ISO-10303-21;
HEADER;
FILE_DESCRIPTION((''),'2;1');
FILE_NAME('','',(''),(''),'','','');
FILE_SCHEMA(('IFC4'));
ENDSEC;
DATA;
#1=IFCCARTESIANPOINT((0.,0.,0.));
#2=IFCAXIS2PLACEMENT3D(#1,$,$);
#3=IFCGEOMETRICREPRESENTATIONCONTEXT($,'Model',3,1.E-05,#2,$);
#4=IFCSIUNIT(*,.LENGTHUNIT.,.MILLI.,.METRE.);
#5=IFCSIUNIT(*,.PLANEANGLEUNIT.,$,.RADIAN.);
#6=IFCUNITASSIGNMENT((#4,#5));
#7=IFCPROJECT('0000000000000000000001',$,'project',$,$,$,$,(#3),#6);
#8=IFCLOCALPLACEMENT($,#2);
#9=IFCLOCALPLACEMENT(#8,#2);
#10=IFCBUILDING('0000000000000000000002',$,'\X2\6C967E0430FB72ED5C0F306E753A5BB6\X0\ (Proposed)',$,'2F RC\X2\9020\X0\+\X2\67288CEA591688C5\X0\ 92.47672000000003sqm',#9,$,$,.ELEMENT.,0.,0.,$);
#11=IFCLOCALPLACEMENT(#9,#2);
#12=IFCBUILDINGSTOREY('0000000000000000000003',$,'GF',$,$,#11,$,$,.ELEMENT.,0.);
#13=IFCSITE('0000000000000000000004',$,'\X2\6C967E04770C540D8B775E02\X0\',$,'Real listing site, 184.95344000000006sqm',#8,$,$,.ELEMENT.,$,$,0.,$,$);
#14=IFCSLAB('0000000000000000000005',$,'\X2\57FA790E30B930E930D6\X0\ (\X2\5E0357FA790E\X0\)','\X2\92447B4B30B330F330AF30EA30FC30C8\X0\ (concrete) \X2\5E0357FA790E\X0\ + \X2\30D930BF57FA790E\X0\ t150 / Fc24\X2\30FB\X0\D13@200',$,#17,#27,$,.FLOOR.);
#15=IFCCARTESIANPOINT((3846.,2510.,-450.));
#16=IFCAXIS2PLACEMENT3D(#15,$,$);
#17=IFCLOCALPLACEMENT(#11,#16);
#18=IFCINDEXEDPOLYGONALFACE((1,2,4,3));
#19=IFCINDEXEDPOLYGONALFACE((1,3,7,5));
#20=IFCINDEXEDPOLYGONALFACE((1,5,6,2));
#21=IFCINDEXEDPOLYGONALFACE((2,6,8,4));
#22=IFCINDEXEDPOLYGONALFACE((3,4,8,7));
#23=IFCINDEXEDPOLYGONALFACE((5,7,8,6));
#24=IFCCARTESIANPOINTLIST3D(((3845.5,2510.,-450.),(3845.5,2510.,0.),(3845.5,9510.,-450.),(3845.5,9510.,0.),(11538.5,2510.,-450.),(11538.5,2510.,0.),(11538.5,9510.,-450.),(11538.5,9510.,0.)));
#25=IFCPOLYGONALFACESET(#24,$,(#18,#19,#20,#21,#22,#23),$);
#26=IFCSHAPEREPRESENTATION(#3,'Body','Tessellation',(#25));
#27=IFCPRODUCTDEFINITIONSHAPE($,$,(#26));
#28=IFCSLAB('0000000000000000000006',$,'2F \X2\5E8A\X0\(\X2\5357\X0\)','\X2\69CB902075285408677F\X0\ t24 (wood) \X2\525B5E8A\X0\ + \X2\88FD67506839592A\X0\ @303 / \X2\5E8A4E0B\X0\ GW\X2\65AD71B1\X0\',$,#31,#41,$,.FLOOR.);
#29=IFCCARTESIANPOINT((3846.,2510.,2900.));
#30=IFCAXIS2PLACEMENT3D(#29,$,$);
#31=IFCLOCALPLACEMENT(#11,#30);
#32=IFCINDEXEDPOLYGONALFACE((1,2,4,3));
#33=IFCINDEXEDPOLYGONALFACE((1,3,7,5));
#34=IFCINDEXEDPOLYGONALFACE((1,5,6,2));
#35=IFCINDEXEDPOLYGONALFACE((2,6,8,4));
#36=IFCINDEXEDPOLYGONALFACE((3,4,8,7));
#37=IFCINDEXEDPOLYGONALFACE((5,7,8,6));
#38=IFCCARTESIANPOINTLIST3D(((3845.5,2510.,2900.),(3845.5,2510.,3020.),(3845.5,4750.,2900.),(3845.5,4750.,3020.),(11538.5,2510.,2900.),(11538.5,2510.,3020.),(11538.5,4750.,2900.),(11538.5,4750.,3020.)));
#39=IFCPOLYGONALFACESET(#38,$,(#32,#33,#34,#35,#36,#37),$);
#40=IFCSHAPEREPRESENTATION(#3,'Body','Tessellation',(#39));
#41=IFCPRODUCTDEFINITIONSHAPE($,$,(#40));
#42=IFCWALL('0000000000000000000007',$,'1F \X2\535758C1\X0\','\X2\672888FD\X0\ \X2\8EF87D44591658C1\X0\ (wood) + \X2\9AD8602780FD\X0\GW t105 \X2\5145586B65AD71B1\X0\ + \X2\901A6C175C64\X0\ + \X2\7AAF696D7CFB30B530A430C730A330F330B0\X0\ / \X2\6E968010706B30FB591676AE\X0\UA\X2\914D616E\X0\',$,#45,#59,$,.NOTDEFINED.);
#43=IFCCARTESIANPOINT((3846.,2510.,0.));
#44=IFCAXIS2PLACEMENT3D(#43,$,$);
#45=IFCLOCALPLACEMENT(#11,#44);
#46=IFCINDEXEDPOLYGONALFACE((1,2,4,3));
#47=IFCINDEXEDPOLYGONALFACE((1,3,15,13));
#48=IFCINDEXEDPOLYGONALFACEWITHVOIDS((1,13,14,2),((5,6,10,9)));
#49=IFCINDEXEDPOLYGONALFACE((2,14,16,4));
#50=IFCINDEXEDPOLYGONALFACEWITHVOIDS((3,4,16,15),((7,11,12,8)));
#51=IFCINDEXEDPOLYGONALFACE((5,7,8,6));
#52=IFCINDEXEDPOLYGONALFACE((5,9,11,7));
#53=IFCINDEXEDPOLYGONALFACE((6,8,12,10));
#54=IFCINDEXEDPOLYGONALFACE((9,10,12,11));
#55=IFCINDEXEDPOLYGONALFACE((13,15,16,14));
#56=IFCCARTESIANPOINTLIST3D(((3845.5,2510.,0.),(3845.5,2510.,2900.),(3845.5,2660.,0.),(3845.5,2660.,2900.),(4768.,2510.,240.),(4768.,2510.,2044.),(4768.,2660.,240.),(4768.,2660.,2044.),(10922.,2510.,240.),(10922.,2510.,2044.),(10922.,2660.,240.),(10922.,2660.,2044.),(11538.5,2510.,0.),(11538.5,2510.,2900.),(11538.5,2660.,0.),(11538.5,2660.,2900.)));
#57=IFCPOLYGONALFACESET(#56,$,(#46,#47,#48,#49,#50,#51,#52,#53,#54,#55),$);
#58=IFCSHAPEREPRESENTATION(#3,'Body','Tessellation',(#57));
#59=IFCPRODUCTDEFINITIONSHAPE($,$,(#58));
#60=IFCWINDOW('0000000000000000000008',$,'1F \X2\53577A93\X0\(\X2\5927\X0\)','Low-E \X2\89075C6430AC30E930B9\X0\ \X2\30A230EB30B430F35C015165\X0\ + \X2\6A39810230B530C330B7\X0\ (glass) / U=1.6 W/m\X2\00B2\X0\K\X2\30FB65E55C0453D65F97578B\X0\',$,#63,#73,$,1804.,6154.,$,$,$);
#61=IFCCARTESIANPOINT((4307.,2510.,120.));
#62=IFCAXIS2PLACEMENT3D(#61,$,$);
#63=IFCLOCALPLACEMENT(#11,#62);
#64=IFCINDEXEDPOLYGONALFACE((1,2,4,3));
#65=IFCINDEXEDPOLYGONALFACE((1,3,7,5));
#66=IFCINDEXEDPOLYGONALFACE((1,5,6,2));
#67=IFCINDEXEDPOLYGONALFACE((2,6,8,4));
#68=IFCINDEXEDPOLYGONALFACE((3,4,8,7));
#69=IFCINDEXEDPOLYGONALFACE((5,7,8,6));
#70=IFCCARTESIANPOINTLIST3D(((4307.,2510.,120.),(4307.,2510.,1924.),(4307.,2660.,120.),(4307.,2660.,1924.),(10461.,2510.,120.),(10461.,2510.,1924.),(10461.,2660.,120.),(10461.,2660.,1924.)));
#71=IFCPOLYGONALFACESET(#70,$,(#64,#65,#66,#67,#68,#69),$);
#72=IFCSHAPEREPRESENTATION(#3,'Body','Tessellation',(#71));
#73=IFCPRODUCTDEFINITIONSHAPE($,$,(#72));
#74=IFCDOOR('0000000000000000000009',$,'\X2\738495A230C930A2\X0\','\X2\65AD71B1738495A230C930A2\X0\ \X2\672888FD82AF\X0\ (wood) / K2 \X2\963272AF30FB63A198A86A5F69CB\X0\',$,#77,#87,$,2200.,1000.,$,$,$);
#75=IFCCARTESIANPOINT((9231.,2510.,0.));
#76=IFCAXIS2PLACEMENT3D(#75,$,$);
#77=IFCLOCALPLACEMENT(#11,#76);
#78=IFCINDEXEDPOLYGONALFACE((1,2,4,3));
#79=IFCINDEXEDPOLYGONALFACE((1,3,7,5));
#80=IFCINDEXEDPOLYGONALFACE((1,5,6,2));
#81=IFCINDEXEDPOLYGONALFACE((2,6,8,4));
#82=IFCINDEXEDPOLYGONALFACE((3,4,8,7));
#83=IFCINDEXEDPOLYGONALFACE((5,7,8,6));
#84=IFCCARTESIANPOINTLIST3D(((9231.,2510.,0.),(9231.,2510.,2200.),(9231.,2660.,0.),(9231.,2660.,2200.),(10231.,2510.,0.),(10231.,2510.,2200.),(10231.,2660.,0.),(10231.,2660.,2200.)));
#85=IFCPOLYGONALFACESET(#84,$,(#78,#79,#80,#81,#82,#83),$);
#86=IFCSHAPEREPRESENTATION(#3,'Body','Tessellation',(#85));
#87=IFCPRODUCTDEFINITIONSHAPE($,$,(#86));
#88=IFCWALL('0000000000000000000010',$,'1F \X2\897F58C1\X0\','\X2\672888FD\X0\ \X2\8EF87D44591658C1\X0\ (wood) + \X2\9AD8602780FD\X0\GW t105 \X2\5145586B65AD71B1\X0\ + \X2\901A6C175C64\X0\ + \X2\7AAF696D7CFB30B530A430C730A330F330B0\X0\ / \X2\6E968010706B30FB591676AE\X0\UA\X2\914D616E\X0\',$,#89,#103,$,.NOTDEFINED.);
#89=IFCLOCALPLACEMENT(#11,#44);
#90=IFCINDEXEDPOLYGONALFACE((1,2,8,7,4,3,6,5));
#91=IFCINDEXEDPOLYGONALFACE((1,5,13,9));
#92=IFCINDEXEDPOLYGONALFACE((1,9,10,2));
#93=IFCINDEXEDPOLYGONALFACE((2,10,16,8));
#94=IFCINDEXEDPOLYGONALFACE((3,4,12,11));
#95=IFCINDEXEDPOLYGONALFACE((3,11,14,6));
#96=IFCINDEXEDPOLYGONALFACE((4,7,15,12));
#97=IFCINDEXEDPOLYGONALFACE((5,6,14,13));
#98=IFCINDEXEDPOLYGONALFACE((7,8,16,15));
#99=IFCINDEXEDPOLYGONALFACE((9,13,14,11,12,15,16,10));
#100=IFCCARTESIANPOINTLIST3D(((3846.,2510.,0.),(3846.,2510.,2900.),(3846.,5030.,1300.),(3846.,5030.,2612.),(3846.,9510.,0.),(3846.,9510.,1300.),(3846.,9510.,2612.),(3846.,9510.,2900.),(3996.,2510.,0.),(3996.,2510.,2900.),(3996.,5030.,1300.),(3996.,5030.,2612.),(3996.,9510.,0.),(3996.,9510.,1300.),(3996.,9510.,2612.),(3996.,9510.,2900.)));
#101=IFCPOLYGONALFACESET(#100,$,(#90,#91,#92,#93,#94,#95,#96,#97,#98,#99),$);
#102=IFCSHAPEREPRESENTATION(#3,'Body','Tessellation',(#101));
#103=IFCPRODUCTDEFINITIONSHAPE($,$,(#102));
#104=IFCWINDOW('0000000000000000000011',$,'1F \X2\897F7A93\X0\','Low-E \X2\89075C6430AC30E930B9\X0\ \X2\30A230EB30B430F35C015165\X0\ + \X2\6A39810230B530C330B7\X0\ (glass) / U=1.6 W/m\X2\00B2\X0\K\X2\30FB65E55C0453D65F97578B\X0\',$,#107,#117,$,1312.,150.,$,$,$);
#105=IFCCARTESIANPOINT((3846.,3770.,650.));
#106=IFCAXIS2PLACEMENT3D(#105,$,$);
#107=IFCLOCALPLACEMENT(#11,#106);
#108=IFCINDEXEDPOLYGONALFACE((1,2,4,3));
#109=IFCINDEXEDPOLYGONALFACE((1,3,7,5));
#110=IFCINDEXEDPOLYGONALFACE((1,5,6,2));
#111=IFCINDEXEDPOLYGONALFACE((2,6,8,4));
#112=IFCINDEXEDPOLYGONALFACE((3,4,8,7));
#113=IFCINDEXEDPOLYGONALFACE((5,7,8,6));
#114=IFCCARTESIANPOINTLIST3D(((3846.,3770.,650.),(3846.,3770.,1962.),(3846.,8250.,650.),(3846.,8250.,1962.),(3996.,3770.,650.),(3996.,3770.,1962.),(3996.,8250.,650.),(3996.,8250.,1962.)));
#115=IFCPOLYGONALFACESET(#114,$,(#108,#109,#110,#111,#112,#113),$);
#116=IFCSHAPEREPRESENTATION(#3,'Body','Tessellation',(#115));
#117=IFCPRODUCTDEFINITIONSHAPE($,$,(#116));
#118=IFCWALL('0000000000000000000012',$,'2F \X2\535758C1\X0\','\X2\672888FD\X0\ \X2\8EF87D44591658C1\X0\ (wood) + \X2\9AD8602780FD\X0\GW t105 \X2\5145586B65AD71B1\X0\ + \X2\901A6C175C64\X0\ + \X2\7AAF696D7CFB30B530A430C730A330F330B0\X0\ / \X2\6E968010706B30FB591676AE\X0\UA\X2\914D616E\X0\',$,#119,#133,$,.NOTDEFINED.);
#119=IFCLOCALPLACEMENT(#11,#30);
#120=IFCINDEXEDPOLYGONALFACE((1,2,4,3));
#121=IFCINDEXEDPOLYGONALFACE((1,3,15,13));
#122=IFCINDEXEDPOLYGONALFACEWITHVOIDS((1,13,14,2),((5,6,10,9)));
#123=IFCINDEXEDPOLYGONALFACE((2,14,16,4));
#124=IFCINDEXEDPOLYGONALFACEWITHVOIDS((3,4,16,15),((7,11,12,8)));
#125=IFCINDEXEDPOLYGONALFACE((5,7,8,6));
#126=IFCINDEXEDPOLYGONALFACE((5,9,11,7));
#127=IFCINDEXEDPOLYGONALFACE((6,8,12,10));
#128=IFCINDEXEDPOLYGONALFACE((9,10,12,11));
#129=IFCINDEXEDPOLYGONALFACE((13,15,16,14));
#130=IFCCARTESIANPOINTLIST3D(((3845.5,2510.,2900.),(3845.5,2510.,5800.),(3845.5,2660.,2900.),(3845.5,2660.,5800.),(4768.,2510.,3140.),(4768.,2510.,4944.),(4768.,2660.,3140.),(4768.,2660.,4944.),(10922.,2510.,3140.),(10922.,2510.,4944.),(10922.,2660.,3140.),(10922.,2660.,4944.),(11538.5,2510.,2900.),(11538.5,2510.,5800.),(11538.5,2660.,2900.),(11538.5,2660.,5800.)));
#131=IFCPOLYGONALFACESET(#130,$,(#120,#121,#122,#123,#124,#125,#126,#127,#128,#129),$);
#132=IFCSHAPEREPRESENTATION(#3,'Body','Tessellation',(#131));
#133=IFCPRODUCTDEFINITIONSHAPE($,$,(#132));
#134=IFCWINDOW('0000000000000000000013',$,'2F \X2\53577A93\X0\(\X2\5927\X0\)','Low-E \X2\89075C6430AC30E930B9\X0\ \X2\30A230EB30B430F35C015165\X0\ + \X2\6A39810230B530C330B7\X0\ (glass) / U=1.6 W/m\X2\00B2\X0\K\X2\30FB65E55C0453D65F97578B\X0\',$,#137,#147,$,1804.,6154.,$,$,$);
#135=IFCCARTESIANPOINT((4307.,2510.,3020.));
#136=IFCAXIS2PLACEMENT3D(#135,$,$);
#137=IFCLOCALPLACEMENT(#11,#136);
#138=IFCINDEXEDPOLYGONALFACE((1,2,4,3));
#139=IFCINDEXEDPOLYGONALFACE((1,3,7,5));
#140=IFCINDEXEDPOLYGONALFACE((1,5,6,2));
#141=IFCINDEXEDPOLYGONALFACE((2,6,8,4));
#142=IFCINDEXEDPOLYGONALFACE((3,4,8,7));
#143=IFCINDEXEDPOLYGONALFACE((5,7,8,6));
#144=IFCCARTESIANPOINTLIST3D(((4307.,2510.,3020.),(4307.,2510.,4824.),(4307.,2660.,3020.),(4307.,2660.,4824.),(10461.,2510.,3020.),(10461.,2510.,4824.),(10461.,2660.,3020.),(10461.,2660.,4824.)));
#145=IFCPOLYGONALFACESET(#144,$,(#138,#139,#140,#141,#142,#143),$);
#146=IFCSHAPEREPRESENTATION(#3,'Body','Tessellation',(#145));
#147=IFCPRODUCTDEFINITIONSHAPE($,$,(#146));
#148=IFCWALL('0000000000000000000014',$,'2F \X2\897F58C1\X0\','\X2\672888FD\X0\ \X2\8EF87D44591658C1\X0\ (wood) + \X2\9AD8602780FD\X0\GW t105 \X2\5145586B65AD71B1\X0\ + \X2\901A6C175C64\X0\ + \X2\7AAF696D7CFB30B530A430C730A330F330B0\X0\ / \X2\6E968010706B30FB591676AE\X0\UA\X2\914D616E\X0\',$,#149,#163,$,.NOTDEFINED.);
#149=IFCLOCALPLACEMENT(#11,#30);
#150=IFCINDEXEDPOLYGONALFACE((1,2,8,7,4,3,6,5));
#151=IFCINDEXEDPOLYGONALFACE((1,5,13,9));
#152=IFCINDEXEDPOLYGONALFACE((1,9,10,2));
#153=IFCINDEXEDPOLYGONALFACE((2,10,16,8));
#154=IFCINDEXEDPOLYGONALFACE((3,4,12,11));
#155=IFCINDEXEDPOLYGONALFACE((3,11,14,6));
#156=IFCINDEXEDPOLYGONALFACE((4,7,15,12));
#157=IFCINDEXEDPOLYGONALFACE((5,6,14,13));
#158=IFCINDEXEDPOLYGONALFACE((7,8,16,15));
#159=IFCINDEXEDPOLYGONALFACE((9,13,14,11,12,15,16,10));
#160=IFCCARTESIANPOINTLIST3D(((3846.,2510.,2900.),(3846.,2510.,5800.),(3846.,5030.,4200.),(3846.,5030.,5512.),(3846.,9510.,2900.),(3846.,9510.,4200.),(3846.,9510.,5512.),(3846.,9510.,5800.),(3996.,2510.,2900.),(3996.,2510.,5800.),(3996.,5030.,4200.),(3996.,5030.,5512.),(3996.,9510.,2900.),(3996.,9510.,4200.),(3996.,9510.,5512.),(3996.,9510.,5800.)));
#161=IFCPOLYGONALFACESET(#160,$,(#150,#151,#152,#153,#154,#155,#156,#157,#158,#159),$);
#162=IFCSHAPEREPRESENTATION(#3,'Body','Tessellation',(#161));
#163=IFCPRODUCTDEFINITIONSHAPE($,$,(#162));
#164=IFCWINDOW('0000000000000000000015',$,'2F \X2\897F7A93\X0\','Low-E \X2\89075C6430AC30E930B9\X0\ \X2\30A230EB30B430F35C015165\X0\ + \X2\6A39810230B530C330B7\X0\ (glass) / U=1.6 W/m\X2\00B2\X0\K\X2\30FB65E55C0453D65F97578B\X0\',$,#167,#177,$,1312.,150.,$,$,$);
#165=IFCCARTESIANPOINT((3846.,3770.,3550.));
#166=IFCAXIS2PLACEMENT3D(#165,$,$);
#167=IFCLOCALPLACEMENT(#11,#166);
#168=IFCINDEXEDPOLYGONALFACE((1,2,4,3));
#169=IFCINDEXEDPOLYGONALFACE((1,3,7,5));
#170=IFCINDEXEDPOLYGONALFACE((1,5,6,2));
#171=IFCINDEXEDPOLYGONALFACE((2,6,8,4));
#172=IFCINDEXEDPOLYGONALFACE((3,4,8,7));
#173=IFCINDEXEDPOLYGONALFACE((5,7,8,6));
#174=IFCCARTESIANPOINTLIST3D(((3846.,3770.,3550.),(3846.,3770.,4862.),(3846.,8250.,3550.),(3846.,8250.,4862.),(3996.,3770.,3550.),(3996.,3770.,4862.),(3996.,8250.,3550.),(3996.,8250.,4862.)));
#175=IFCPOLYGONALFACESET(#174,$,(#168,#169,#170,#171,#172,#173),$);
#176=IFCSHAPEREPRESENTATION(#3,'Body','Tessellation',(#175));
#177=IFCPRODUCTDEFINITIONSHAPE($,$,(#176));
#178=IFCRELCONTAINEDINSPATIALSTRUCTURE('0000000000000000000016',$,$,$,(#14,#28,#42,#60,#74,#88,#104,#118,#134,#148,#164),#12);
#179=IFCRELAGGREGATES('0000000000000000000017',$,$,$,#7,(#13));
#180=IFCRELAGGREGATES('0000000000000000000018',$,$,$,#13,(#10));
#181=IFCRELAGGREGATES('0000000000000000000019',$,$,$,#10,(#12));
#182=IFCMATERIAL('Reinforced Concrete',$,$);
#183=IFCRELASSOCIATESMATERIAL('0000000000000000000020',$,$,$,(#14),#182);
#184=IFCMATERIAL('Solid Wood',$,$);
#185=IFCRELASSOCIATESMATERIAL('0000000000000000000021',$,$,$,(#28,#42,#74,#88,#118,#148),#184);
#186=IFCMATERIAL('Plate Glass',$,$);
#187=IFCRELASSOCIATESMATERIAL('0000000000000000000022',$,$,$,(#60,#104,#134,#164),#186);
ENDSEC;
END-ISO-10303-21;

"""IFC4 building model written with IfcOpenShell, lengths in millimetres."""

from ifc_helpers import new_model, si_unit, frame, frame_2d, origin, place, context, project, spatial, rectangle, extrude, material, element, fill, save


model = new_model("IFC4")

# Units and contexts
model_context = context("Model", 3, precision=1e-05, world=origin())
ifc_project = project(units=[si_unit("LENGTHUNIT", "METRE", prefix="MILLI"), si_unit("PLANEANGLEUNIT", "RADIAN")], contexts=[model_context])

# Site, building, storey
site_placement = place(None, origin())
site = spatial("IfcSite", under=ifc_project, at=site_placement, Name="沖縄県名護市", ObjectType="Real listing site, 184.95344000000006sqm", CompositionType="ELEMENT", RefElevation=0.0)
building_placement = place(site_placement, origin())
building = spatial("IfcBuilding", under=site, at=building_placement, Name="沖縄・狭小の町家 (Proposed)", ObjectType="2F RC造+木質外装 92.47672000000003sqm", CompositionType="ELEMENT", ElevationOfRefHeight=0.0, ElevationOfTerrain=0.0)
storey_placement = place(building_placement, origin())
storey = spatial("IfcBuildingStorey", under=building, at=storey_placement, Name="GF", CompositionType="ELEMENT", Elevation=0.0)

# Slabs
ifc_material_1 = material(Name="Reinforced Concrete")
slab_1_placement = place(storey_placement, frame((3846.0, 2510.0, -450.0)))
element("IfcSlab", 1, at=slab_1_placement, inside=storey, material=ifc_material_1, Name="基礎スラブ (布基礎)", Description="鉄筋コンクリート (concrete) 布基礎 + ベタ基礎 t150 / Fc24・D13@200", PredefinedType="FLOOR", context=model_context, shape_type="SweptSolid", body=[
    extrude(rectangle(XDim=7693.0, YDim=7000.0, at=frame_2d((3846.0, 3500.0))), frame((3846.0, 2510.0, -450.0)), (0.0, 0.0, 1.0), 450.0),
])
ifc_material_2 = material(Name="Solid Wood")
slab_2_placement = place(storey_placement, frame((3846.0, 2510.0, 2900.0)))
element("IfcSlab", 2, at=slab_2_placement, inside=storey, material=ifc_material_2, Name="2F 床(南)", Description="構造用合板 t24 (wood) 剛床 + 製材根太 @303 / 床下 GW断熱", PredefinedType="FLOOR", context=model_context, shape_type="SweptSolid", body=[
    extrude(rectangle(XDim=7693.0, YDim=2240.0, at=frame_2d((3846.0, 1120.0))), frame((3846.0, 2510.0, 2900.0)), (0.0, 0.0, 1.0), 120.0),
])

# Wall, openings, window, door
wall_1_placement = place(storey_placement, frame((3846.0, 2510.0, 0.0)))
wall_1 = element("IfcWall", 3, at=wall_1_placement, inside=storey, material=ifc_material_2, Name="1F 南壁", Description="木製 軸組外壁 (wood) + 高性能GW t105 充填断熱 + 通気層 + 窯業系サイディング / 準耐火・外皮UA配慮", PredefinedType="NOTDEFINED", context=model_context, shape_type="SweptSolid", body=[
    extrude(rectangle(XDim=7693.0, YDim=150.0, at=frame_2d((3846.0, 75.0))), frame((3846.0, 2510.0, 0.0)), (0.0, 0.0, 1.0), 2900.0),
])
opening_1_placement = place(storey_placement, frame((4307.0, 2510.0, 120.0)))
opening_1 = element("IfcOpeningElement", 4, at=opening_1_placement, cuts=wall_1, PredefinedType="NOTDEFINED", context=model_context, shape_type="SweptSolid", body=[
    extrude(rectangle(XDim=6154.0, YDim=150.0, at=frame_2d((3077.0, 75.0))), frame((4307.0, 2510.0, 120.0)), (0.0, 0.0, 1.0), 1804.0),
])
opening_2_placement = place(storey_placement, frame((9231.0, 2510.0, 0.0)))
opening_2 = element("IfcOpeningElement", 5, at=opening_2_placement, cuts=wall_1, PredefinedType="NOTDEFINED", context=model_context, shape_type="SweptSolid", body=[
    extrude(rectangle(XDim=1000.0, YDim=150.0, at=frame_2d((500.0, 75.0))), frame((9231.0, 2510.0, 0.0)), (0.0, 0.0, 1.0), 2200.0),
])
ifc_material_3 = material(Name="Plate Glass")
window_1_placement = place(storey_placement, frame((4307.0, 2510.0, 120.0)))
window_1 = element("IfcWindow", 6, at=window_1_placement, inside=storey, material=ifc_material_3, Name="1F 南窓(大)", Description="Low-E 複層ガラス アルゴン封入 + 樹脂サッシ (glass) / U=1.6 W/m²K・日射取得型", OverallHeight=1804.0, OverallWidth=6154.0, context=model_context, shape_type="SweptSolid", body=[
    extrude(rectangle(XDim=6154.0, YDim=150.0, at=frame_2d((3077.0, 75.0))), frame((4307.0, 2510.0, 120.0)), (0.0, 0.0, 1.0), 1804.0),
])
fill(opening_1, window_1)
door_placement = place(storey_placement, frame((9231.0, 2510.0, 0.0)))
door = element("IfcDoor", 7, at=door_placement, inside=storey, material=ifc_material_2, Name="玄関ドア", Description="断熱玄関ドア 木製芯 (wood) / K2 防犯・採風機構", OverallHeight=2200.0, OverallWidth=1000.0, context=model_context, shape_type="SweptSolid", body=[
    extrude(rectangle(XDim=1000.0, YDim=150.0, at=frame_2d((500.0, 75.0))), frame((9231.0, 2510.0, 0.0)), (0.0, 0.0, 1.0), 2200.0),
])
fill(opening_2, door)

# Walls, openings, windows
wall_2_placement = place(storey_placement, frame((3846.0, 2510.0, 0.0)))
wall_2 = element("IfcWall", 8, at=wall_2_placement, inside=storey, material=ifc_material_2, Name="1F 西壁", Description="木製 軸組外壁 (wood) + 高性能GW t105 充填断熱 + 通気層 + 窯業系サイディング / 準耐火・外皮UA配慮", PredefinedType="NOTDEFINED", context=model_context, shape_type="SweptSolid", body=[
    extrude(rectangle(XDim=150.0, YDim=7000.0, at=frame_2d((75.0, 3500.0))), frame((3846.0, 2510.0, 0.0)), (0.0, 0.0, 1.0), 2900.0),
])
opening_3_placement = place(storey_placement, frame((3846.0, 3770.0, 650.0)))
opening_3 = element("IfcOpeningElement", 9, at=opening_3_placement, cuts=wall_2, PredefinedType="NOTDEFINED", context=model_context, shape_type="SweptSolid", body=[
    extrude(rectangle(XDim=150.0, YDim=4480.0, at=frame_2d((75.0, 2240.0))), frame((3846.0, 3770.0, 650.0)), (0.0, 0.0, 1.0), 1312.0),
])
window_2_placement = place(storey_placement, frame((3846.0, 3770.0, 650.0)))
window_2 = element("IfcWindow", 10, at=window_2_placement, inside=storey, material=ifc_material_3, Name="1F 西窓", Description="Low-E 複層ガラス アルゴン封入 + 樹脂サッシ (glass) / U=1.6 W/m²K・日射取得型", OverallHeight=1312.0, OverallWidth=150.0, context=model_context, shape_type="SweptSolid", body=[
    extrude(rectangle(XDim=150.0, YDim=4480.0, at=frame_2d((75.0, 2240.0))), frame((3846.0, 3770.0, 650.0)), (0.0, 0.0, 1.0), 1312.0),
])
fill(opening_3, window_2)
wall_3_placement = place(storey_placement, frame((3846.0, 2510.0, 2900.0)))
wall_3 = element("IfcWall", 11, at=wall_3_placement, inside=storey, material=ifc_material_2, Name="2F 南壁", Description="木製 軸組外壁 (wood) + 高性能GW t105 充填断熱 + 通気層 + 窯業系サイディング / 準耐火・外皮UA配慮", PredefinedType="NOTDEFINED", context=model_context, shape_type="SweptSolid", body=[
    extrude(rectangle(XDim=7693.0, YDim=150.0, at=frame_2d((3846.0, 75.0))), frame((3846.0, 2510.0, 2900.0)), (0.0, 0.0, 1.0), 2900.0),
])
opening_4_placement = place(storey_placement, frame((4307.0, 2510.0, 3020.0)))
opening_4 = element("IfcOpeningElement", 12, at=opening_4_placement, cuts=wall_3, PredefinedType="NOTDEFINED", context=model_context, shape_type="SweptSolid", body=[
    extrude(rectangle(XDim=6154.0, YDim=150.0, at=frame_2d((3077.0, 75.0))), frame((4307.0, 2510.0, 3020.0)), (0.0, 0.0, 1.0), 1804.0),
])
window_3_placement = place(storey_placement, frame((4307.0, 2510.0, 3020.0)))
window_3 = element("IfcWindow", 13, at=window_3_placement, inside=storey, material=ifc_material_3, Name="2F 南窓(大)", Description="Low-E 複層ガラス アルゴン封入 + 樹脂サッシ (glass) / U=1.6 W/m²K・日射取得型", OverallHeight=1804.0, OverallWidth=6154.0, context=model_context, shape_type="SweptSolid", body=[
    extrude(rectangle(XDim=6154.0, YDim=150.0, at=frame_2d((3077.0, 75.0))), frame((4307.0, 2510.0, 3020.0)), (0.0, 0.0, 1.0), 1804.0),
])
fill(opening_4, window_3)
wall_4_placement = place(storey_placement, frame((3846.0, 2510.0, 2900.0)))
wall_4 = element("IfcWall", 14, at=wall_4_placement, inside=storey, material=ifc_material_2, Name="2F 西壁", Description="木製 軸組外壁 (wood) + 高性能GW t105 充填断熱 + 通気層 + 窯業系サイディング / 準耐火・外皮UA配慮", PredefinedType="NOTDEFINED", context=model_context, shape_type="SweptSolid", body=[
    extrude(rectangle(XDim=150.0, YDim=7000.0, at=frame_2d((75.0, 3500.0))), frame((3846.0, 2510.0, 2900.0)), (0.0, 0.0, 1.0), 2900.0),
])
opening_5_placement = place(storey_placement, frame((3846.0, 3770.0, 3550.0)))
opening_5 = element("IfcOpeningElement", 15, at=opening_5_placement, cuts=wall_4, PredefinedType="NOTDEFINED", context=model_context, shape_type="SweptSolid", body=[
    extrude(rectangle(XDim=150.0, YDim=4480.0, at=frame_2d((75.0, 2240.0))), frame((3846.0, 3770.0, 3550.0)), (0.0, 0.0, 1.0), 1312.0),
])
window_4_placement = place(storey_placement, frame((3846.0, 3770.0, 3550.0)))
window_4 = element("IfcWindow", 16, at=window_4_placement, inside=storey, material=ifc_material_3, Name="2F 西窓", Description="Low-E 複層ガラス アルゴン封入 + 樹脂サッシ (glass) / U=1.6 W/m²K・日射取得型", OverallHeight=1312.0, OverallWidth=150.0, context=model_context, shape_type="SweptSolid", body=[
    extrude(rectangle(XDim=150.0, YDim=4480.0, at=frame_2d((75.0, 2240.0))), frame((3846.0, 3770.0, 3550.0)), (0.0, 0.0, 1.0), 1312.0),
])
fill(opening_5, window_4)

save(model, "model.ifc")
